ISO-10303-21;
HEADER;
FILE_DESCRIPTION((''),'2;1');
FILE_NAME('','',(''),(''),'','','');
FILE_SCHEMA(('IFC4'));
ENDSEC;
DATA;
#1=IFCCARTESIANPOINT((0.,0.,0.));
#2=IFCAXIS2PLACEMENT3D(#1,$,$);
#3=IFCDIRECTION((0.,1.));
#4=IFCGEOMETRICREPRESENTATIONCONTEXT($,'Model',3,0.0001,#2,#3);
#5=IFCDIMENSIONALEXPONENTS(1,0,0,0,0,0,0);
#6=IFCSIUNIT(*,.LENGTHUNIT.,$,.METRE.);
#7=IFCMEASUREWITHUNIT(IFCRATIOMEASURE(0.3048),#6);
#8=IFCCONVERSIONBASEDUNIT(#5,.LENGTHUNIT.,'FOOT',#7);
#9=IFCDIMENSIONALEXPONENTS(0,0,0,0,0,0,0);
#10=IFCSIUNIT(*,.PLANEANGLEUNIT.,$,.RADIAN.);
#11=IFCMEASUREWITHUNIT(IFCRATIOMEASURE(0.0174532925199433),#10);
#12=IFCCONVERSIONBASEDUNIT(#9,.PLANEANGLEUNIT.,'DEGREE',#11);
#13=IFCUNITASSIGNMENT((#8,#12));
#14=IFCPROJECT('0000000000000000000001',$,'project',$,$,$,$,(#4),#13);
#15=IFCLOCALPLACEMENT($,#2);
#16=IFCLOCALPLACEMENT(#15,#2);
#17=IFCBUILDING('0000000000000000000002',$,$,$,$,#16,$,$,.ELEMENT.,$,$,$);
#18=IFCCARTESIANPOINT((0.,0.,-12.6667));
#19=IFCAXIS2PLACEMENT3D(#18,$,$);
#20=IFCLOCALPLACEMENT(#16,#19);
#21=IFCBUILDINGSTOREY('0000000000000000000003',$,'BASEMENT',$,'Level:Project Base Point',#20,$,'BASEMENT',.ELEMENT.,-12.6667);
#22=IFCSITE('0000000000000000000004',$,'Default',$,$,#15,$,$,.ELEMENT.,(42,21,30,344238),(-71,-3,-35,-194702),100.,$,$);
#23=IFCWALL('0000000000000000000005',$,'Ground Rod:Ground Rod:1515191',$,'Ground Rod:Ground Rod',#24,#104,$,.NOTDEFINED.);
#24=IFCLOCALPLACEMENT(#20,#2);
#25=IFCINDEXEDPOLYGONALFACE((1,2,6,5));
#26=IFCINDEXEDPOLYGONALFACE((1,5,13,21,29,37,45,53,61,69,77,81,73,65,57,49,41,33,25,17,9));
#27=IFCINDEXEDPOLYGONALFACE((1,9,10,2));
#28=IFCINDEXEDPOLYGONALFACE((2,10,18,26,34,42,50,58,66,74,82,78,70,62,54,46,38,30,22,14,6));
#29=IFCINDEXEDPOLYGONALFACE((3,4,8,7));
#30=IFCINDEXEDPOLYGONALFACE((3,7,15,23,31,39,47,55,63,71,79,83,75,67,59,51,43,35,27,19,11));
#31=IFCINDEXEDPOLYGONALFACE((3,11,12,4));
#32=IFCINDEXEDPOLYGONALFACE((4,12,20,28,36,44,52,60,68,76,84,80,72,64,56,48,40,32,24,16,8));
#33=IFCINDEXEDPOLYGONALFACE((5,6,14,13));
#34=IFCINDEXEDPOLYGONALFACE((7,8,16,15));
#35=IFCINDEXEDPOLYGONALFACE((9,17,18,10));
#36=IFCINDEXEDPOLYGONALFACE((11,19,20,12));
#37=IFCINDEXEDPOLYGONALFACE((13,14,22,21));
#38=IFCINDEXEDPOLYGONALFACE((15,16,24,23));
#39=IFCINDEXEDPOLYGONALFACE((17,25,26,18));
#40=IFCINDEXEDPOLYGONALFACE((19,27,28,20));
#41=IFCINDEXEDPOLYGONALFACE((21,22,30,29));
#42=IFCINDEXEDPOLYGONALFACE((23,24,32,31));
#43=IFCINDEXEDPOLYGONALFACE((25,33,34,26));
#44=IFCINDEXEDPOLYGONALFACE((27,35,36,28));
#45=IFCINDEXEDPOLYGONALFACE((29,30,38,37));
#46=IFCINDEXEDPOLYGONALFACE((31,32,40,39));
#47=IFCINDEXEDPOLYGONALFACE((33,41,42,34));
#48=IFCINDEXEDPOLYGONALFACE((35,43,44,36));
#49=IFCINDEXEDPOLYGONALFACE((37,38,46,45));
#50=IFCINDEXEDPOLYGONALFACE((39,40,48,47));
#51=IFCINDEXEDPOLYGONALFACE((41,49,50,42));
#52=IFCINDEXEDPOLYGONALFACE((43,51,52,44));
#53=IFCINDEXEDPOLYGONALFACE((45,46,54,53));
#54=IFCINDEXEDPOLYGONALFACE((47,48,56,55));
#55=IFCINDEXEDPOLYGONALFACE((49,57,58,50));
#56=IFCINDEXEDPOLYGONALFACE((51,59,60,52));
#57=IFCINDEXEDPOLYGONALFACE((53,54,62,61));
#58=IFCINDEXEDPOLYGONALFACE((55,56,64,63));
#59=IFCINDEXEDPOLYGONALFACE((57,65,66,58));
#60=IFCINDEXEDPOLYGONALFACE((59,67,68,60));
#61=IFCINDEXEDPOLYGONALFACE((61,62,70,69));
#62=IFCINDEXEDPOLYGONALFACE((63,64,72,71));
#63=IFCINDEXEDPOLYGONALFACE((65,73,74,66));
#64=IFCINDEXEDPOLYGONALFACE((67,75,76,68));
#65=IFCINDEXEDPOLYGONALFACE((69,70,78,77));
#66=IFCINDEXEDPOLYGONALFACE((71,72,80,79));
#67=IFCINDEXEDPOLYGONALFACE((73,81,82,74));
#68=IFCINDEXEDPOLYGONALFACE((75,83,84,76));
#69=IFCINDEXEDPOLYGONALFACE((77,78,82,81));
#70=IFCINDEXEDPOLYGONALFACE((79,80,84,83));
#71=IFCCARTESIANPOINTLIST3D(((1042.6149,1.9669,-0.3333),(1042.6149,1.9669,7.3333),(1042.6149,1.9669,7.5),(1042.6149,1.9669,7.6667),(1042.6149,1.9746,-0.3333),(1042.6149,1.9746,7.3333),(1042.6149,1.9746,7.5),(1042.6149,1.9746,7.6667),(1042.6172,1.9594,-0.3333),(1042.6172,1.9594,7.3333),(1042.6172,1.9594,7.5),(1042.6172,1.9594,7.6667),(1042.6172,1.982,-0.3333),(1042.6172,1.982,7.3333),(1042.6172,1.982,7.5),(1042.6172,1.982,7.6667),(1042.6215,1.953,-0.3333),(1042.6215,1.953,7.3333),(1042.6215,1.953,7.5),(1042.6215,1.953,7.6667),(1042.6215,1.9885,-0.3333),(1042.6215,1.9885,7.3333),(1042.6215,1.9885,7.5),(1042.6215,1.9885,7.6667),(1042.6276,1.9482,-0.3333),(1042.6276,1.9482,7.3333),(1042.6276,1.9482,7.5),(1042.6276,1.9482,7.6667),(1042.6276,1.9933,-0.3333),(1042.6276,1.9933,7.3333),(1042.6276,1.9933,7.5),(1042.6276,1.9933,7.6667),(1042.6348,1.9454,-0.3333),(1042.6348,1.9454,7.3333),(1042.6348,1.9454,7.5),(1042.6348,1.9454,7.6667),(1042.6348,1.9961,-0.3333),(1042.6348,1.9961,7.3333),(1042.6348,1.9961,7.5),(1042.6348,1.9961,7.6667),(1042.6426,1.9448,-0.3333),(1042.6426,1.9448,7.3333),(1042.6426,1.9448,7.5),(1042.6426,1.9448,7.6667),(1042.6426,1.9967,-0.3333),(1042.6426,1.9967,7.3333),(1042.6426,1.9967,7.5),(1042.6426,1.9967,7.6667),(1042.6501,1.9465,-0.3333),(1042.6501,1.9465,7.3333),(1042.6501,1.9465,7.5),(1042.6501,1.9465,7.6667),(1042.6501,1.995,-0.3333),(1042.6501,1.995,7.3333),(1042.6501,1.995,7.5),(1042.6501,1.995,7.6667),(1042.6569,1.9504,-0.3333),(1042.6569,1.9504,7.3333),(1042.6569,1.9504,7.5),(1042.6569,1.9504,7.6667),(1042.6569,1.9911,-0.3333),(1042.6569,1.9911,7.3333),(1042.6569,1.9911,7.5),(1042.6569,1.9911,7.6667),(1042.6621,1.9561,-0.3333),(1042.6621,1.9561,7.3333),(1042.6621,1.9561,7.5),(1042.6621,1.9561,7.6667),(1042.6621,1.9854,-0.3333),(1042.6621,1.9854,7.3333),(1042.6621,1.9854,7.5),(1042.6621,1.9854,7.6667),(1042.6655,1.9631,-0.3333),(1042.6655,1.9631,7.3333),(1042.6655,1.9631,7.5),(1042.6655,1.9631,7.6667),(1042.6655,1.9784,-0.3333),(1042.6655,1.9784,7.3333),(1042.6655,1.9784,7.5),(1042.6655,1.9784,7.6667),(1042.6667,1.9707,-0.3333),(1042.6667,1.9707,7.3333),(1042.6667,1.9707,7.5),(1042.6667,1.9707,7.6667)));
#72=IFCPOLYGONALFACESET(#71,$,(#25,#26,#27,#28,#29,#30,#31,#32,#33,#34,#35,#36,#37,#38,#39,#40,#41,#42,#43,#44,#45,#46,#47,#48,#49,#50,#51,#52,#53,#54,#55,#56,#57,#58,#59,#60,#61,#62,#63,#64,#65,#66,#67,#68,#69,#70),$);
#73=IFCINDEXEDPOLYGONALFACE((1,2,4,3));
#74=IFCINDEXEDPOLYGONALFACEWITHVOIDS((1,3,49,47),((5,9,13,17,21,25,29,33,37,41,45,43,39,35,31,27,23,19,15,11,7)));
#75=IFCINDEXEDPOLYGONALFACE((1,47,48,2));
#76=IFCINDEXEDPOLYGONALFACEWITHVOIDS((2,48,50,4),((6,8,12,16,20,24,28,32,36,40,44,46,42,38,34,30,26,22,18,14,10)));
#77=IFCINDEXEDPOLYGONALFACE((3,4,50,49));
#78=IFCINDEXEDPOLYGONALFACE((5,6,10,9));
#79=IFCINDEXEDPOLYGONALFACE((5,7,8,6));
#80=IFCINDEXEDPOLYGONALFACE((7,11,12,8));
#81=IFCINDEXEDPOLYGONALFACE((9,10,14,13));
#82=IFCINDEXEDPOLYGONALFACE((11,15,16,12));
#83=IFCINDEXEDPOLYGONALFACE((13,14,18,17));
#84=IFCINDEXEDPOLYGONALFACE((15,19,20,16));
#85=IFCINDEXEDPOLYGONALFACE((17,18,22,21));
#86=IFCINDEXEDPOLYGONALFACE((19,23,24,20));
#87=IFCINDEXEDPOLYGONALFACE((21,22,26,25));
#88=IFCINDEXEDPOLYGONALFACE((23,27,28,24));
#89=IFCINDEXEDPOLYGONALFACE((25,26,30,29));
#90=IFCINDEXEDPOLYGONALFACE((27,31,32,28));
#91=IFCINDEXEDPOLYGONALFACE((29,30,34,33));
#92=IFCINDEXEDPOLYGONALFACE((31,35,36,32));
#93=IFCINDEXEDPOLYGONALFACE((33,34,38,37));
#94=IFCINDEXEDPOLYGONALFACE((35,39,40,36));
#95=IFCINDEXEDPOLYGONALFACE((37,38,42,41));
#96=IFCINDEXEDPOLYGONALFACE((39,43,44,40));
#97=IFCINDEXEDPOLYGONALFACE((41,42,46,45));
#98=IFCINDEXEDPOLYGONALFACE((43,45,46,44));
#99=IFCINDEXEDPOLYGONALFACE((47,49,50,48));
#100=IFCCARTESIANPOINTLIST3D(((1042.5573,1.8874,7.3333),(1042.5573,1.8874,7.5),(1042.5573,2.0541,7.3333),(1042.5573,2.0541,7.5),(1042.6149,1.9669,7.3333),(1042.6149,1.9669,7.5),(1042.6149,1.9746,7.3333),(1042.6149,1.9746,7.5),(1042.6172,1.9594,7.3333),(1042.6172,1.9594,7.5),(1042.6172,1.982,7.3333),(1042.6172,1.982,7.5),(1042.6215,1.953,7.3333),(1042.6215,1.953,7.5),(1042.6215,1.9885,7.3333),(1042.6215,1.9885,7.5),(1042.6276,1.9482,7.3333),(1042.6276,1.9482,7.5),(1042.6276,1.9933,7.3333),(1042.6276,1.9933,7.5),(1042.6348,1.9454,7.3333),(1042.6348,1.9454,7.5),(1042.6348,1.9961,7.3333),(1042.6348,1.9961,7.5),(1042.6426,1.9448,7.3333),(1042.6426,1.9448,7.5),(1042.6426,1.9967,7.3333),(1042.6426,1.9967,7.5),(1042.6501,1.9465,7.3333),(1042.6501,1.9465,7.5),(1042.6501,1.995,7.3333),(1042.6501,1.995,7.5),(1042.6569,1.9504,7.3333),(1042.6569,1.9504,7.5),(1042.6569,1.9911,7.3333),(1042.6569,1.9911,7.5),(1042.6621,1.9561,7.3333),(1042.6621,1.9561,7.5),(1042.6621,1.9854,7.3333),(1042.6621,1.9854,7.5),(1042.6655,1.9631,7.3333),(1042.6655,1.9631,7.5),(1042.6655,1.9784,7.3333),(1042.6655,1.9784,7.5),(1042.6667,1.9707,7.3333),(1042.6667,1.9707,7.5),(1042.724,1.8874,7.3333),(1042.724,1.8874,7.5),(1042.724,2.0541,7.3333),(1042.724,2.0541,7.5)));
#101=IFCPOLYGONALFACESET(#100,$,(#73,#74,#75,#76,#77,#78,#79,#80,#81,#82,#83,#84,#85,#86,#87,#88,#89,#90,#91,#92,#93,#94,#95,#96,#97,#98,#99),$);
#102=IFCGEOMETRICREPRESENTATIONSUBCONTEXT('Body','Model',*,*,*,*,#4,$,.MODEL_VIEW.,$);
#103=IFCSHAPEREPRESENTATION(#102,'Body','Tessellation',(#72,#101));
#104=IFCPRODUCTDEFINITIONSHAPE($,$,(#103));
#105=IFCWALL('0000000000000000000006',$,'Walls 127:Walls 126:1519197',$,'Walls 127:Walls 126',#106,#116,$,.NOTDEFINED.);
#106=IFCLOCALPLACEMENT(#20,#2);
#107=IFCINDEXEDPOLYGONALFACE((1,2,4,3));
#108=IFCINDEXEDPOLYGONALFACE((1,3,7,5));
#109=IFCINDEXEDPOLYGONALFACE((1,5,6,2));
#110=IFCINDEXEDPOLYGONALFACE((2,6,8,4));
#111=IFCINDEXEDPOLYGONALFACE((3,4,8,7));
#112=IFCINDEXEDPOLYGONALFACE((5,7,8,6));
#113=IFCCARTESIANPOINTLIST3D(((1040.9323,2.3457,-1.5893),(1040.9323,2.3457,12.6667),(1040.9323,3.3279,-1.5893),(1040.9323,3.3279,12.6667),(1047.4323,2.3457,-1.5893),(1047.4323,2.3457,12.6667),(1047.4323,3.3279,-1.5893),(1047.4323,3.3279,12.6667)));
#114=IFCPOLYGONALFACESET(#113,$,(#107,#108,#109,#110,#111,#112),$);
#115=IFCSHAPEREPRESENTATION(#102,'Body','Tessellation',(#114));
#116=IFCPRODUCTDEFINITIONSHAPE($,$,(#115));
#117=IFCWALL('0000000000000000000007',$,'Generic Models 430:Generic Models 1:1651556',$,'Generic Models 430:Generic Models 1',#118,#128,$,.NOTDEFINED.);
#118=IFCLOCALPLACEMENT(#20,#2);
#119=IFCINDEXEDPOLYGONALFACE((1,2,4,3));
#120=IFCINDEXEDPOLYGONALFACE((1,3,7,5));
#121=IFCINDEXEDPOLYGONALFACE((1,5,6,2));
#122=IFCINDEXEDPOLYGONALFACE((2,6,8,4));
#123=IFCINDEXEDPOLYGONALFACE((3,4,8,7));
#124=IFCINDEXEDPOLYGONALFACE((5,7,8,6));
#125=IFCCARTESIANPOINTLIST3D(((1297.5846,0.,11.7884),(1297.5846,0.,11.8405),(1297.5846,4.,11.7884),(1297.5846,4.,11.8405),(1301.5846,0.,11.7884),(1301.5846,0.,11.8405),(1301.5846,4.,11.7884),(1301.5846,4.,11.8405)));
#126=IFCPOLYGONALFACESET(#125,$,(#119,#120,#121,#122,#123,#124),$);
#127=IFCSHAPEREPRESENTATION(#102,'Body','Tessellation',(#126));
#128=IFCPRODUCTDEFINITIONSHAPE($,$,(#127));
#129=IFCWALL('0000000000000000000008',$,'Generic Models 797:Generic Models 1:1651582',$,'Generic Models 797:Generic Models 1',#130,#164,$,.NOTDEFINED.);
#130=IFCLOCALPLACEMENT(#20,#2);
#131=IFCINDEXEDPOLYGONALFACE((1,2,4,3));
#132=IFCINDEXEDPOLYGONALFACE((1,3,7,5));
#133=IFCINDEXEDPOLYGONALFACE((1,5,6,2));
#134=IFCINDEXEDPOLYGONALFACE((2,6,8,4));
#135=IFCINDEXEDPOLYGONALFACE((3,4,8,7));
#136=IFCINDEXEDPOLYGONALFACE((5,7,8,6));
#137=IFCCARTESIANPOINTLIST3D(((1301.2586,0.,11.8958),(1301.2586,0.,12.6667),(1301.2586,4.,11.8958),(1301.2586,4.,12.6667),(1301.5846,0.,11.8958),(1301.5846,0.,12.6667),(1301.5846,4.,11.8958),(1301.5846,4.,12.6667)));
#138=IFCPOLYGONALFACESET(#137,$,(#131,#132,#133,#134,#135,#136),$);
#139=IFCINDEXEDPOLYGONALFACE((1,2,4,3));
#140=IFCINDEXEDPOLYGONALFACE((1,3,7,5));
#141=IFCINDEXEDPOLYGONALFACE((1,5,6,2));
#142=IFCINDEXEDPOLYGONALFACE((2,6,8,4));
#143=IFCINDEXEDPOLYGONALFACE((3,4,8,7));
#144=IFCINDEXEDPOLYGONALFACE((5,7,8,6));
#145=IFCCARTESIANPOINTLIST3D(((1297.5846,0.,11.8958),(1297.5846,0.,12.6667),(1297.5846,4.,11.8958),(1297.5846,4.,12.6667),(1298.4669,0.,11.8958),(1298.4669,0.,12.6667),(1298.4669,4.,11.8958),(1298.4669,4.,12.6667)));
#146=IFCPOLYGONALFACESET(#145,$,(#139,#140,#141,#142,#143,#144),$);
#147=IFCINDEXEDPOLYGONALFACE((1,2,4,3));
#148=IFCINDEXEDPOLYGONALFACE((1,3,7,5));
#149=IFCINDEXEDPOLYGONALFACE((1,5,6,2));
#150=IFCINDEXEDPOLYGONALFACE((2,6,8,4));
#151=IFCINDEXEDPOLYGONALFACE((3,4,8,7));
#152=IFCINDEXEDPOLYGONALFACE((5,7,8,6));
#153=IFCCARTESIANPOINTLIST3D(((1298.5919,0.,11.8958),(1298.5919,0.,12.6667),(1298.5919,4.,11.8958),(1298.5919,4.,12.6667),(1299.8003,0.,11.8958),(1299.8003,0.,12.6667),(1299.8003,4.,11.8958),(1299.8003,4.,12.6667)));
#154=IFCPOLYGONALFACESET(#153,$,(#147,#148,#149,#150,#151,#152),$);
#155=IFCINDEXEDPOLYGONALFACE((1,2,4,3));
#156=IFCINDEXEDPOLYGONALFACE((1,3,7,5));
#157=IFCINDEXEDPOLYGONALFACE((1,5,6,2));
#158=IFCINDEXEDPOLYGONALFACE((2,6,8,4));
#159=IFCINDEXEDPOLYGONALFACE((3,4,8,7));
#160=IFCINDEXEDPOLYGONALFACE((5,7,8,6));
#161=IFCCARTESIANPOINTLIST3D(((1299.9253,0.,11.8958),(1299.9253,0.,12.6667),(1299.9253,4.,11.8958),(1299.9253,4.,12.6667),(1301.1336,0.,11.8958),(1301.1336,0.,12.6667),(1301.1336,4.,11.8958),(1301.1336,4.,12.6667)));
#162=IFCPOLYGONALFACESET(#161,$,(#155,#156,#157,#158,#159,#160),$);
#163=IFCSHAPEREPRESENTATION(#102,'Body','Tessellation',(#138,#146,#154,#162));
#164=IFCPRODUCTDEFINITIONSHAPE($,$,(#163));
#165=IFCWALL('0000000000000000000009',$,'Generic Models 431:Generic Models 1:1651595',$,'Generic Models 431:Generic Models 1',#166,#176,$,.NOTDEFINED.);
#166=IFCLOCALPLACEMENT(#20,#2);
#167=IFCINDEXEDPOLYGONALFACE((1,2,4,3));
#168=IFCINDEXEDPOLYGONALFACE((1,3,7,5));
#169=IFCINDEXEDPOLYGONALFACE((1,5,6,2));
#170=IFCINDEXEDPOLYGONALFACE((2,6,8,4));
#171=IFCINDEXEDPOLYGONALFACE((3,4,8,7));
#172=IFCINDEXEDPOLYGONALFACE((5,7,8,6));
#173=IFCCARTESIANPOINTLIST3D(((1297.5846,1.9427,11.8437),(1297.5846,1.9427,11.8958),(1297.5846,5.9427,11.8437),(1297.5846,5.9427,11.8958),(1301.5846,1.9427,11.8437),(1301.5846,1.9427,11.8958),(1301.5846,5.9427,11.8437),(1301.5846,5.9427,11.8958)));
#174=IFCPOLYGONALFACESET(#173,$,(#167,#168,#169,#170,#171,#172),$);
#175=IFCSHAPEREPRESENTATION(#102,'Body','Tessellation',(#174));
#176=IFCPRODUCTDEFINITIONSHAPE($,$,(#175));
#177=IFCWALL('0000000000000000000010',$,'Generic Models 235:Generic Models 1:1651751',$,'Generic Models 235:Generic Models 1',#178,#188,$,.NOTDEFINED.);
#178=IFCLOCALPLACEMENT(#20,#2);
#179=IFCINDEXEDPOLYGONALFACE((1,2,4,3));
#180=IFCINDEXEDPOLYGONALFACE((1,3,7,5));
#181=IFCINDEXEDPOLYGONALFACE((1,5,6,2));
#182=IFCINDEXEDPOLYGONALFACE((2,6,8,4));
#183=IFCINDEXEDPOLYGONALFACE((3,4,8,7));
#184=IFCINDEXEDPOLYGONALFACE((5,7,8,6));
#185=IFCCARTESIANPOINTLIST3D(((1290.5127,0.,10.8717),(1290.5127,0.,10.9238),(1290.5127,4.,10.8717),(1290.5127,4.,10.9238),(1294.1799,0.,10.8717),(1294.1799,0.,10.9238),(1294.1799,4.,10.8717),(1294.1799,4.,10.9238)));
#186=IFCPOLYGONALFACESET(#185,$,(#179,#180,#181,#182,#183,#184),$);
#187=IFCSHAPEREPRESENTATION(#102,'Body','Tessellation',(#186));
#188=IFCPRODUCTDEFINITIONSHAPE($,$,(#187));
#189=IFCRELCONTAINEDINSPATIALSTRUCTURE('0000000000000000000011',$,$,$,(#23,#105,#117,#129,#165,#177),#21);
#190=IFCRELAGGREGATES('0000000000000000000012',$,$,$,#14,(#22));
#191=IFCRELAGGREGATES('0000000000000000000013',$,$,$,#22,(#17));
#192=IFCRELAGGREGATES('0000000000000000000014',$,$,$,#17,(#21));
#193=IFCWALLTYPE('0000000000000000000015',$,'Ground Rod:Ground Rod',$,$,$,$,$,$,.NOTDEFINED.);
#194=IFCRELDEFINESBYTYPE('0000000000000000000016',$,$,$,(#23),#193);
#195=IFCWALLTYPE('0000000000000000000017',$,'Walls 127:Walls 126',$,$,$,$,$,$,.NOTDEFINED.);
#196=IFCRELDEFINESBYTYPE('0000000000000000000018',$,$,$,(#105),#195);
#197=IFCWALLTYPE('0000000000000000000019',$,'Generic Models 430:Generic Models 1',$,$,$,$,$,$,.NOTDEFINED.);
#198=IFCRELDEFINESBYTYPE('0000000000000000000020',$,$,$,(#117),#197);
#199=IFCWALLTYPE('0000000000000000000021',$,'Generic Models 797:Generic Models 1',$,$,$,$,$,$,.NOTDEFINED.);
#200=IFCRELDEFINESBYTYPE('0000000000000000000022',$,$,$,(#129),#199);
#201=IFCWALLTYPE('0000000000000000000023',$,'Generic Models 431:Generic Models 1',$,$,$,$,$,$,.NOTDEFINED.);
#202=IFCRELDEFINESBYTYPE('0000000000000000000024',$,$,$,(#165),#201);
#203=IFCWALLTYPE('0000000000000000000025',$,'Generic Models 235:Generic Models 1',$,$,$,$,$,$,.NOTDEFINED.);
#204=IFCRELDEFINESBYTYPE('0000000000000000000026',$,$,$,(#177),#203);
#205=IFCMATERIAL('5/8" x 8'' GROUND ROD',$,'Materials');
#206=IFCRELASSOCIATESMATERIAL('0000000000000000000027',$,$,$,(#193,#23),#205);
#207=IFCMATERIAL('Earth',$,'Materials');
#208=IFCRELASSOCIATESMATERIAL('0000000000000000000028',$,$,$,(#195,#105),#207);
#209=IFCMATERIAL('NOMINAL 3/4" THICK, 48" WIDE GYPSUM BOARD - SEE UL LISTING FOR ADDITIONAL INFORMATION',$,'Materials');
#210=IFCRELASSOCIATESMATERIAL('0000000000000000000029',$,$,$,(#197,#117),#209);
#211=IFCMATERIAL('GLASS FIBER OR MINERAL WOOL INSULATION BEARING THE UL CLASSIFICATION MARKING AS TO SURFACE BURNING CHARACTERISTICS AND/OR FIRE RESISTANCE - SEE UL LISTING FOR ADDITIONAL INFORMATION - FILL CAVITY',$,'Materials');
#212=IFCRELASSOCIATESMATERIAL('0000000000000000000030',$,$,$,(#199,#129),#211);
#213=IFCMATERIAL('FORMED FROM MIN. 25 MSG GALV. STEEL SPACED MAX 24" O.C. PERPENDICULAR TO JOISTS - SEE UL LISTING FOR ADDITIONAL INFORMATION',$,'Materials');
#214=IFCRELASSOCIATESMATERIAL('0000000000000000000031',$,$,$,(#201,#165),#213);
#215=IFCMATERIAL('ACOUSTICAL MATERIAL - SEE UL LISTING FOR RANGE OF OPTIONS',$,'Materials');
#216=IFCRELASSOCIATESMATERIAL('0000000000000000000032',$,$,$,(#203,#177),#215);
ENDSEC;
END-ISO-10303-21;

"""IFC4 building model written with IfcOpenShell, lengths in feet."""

from ifc_helpers import new_model, entity, si_unit, converted_unit, direction, frame, frame_2d, origin, origin_2d_with_axis, place, context, subcontext, project, spatial, rectangle, circle, extrude, material, type_object, element, save


model = new_model("IFC4")

# Units and contexts
model_context = context("Model", 3, precision=0.0001, world=origin(), true_north=direction((0.0, 1.0)))
body_context = subcontext(model_context, "Body", "Model", "MODEL_VIEW")
ifc_project = project(units=[converted_unit("LENGTHUNIT", "FOOT", entity("IfcRatioMeasure", 0.3048), si_unit("LENGTHUNIT", "METRE"), dimensions=[1, 0, 0, 0, 0, 0, 0]), converted_unit("PLANEANGLEUNIT", "DEGREE", entity("IfcRatioMeasure", 0.0174532925199433), si_unit("PLANEANGLEUNIT", "RADIAN"), dimensions=[0, 0, 0, 0, 0, 0, 0])], contexts=[model_context])

# Site, building, storey
site_placement = place(None, origin())
site = spatial("IfcSite", under=ifc_project, at=site_placement, Name="Default", CompositionType="ELEMENT", RefLatitude=(42, 21, 30, 344238), RefLongitude=(-71, -3, -35, -194702), RefElevation=100.0)
building_placement = place(site_placement, origin())
building = spatial("IfcBuilding", under=site, at=building_placement, CompositionType="ELEMENT")
storey_placement = place(building_placement, frame((0.0, 0.0, -12.6667)))
storey = spatial("IfcBuildingStorey", under=building, at=storey_placement, Name="BASEMENT", ObjectType="Level:Project Base Point", LongName="BASEMENT", CompositionType="ELEMENT", Elevation=-12.6667)

# Wall, opening
ifc_material_1 = material(Name="5/8\" x 8' GROUND ROD", Category="Materials")
wall_type_1 = type_object("IfcWallType", Name="Ground Rod:Ground Rod", PredefinedType="NOTDEFINED", material=ifc_material_1)
wall_1_placement = place(storey_placement, frame((1042.5573, 1.8874, -0.3333)))
wall_1 = element("IfcWall", 1, at=wall_1_placement, inside=storey, type_object=wall_type_1, material=ifc_material_1, Name="Ground Rod:Ground Rod:1515191", ObjectType="Ground Rod:Ground Rod", PredefinedType="NOTDEFINED", context=body_context, shape_type="SweptSolid", body=[
    extrude(circle(Radius=0.026, at=origin_2d_with_axis()), frame((0.0833, 0.0833, 0.0)), (0.0, 0.0, 1.0), 8.0),
    extrude(rectangle(XDim=0.1667, YDim=0.1667, at=frame_2d((0.0, 0.0), x_axis=(1.0, 0.0))), frame((0.0833, 0.0833, 7.6667), z_axis=(0.0, 0.0, 1.0), x_axis=(-1.0, 0.0, 0.0)), (0.0, 0.0, 1.0), 0.1667),
])
opening_placement = place(storey_placement, frame((1042.5573, 1.8874, -0.3333)))
element("IfcOpeningElement", 2, at=opening_placement, cuts=wall_1, PredefinedType="OPENING", context=body_context, shape_type="SweptSolid", body=[
    extrude(circle(Radius=0.026, at=frame_2d((0.0, 0.0), x_axis=(1.0, 0.0))), frame((0.0833, 0.0833, 7.6667)), (0.0, 0.0, 1.0), 0.1667),
])

# Walls
ifc_material_2 = material(Name="Earth", Category="Materials")
wall_type_2 = type_object("IfcWallType", Name="Walls 127:Walls 126", PredefinedType="NOTDEFINED", material=ifc_material_2)
wall_2_placement = place(storey_placement, frame((1040.9323, 2.3457, -1.5893)))
element("IfcWall", 3, at=wall_2_placement, inside=storey, type_object=wall_type_2, material=ifc_material_2, Name="Walls 127:Walls 126:1519197", ObjectType="Walls 127:Walls 126", PredefinedType="NOTDEFINED", context=body_context, shape_type="SweptSolid", body=[
    extrude(rectangle(XDim=0.9821, YDim=6.5, at=frame_2d((0.0, 0.0), x_axis=(1.0, 0.0))), frame((3.25, 0.4911, 0.0), z_axis=(0.0, 0.0, 1.0), x_axis=(0.0, 1.0, 0.0)), (0.0, 0.0, 1.0), 14.256),
])
ifc_material_3 = material(Name="NOMINAL 3/4\" THICK, 48\" WIDE GYPSUM BOARD - SEE UL LISTING FOR ADDITIONAL INFORMATION", Category="Materials")
wall_type_3 = type_object("IfcWallType", Name="Generic Models 430:Generic Models 1", PredefinedType="NOTDEFINED", material=ifc_material_3)
wall_3_placement = place(storey_placement, frame((1297.5846, 0.0, 11.7884), z_axis=(0.0, 0.0, 1.0), x_axis=(0.0, 1.0, 0.0)))
element("IfcWall", 4, at=wall_3_placement, inside=storey, type_object=wall_type_3, material=ifc_material_3, Name="Generic Models 430:Generic Models 1:1651556", ObjectType="Generic Models 430:Generic Models 1", PredefinedType="NOTDEFINED", context=body_context, shape_type="SweptSolid", body=[
    extrude(rectangle(XDim=4.0, YDim=4.0, at=origin_2d_with_axis()), frame((2.0, -2.0, 0.0)), (0.0, 0.0, 1.0), 0.0521),
])
ifc_material_4 = material(Name="GLASS FIBER OR MINERAL WOOL INSULATION BEARING THE UL CLASSIFICATION MARKING AS TO SURFACE BURNING CHARACTERISTICS AND/OR FIRE RESISTANCE - SEE UL LISTING FOR ADDITIONAL INFORMATION - FILL CAVITY", Category="Materials")
wall_type_4 = type_object("IfcWallType", Name="Generic Models 797:Generic Models 1", PredefinedType="NOTDEFINED", material=ifc_material_4)
wall_4_placement = place(storey_placement, frame((1297.5846, 0.0, 11.8958), z_axis=(0.0, 0.0, 1.0), x_axis=(0.0, 1.0, 0.0)))
element("IfcWall", 5, at=wall_4_placement, inside=storey, type_object=wall_type_4, material=ifc_material_4, Name="Generic Models 797:Generic Models 1:1651582", ObjectType="Generic Models 797:Generic Models 1", PredefinedType="NOTDEFINED", context=body_context, shape_type="SweptSolid", body=[
    extrude(rectangle(XDim=4.0, YDim=0.326, at=origin_2d_with_axis()), frame((2.0, -3.837, 0.0)), (0.0, 0.0, 1.0), 0.7708),
    extrude(rectangle(XDim=4.0, YDim=0.8824, at=origin_2d_with_axis()), frame((2.0, -0.4412, 0.0)), (0.0, 0.0, 1.0), 0.7708),
    extrude(rectangle(XDim=4.0, YDim=1.2083, at=frame_2d((0.0, 0.0), x_axis=(1.0, 0.0))), frame((2.0, -1.6115, 0.0)), (0.0, 0.0, 1.0), 0.7708),
    extrude(rectangle(XDim=4.0, YDim=1.2083, at=frame_2d((0.0, 0.0), x_axis=(1.0, 0.0))), frame((2.0, -2.9449, 0.0)), (0.0, 0.0, 1.0), 0.7708),
])
ifc_material_5 = material(Name="FORMED FROM MIN. 25 MSG GALV. STEEL SPACED MAX 24\" O.C. PERPENDICULAR TO JOISTS - SEE UL LISTING FOR ADDITIONAL INFORMATION", Category="Materials")
wall_type_5 = type_object("IfcWallType", Name="Generic Models 431:Generic Models 1", PredefinedType="NOTDEFINED", material=ifc_material_5)
wall_5_placement = place(storey_placement, frame((1297.5846, 1.9427, 11.8437), z_axis=(0.0, 0.0, 1.0), x_axis=(0.0, 1.0, 0.0)))
element("IfcWall", 6, at=wall_5_placement, inside=storey, type_object=wall_type_5, material=ifc_material_5, Name="Generic Models 431:Generic Models 1:1651595", ObjectType="Generic Models 431:Generic Models 1", PredefinedType="NOTDEFINED", context=body_context, shape_type="SweptSolid", body=[
    extrude(rectangle(XDim=4.0, YDim=4.0, at=frame_2d((0.0, 0.0), x_axis=(1.0, 0.0))), frame((2.0, -2.0, 0.0)), (0.0, 0.0, 1.0), 0.0521),
])
ifc_material_6 = material(Name="ACOUSTICAL MATERIAL - SEE UL LISTING FOR RANGE OF OPTIONS", Category="Materials")
wall_type_6 = type_object("IfcWallType", Name="Generic Models 235:Generic Models 1", PredefinedType="NOTDEFINED", material=ifc_material_6)
wall_6_placement = place(storey_placement, frame((1290.5127, 0.0, 10.8717), z_axis=(0.0, 0.0, 1.0), x_axis=(0.0, 1.0, 0.0)))
element("IfcWall", 7, at=wall_6_placement, inside=storey, type_object=wall_type_6, material=ifc_material_6, Name="Generic Models 235:Generic Models 1:1651751", ObjectType="Generic Models 235:Generic Models 1", PredefinedType="NOTDEFINED", context=body_context, shape_type="SweptSolid", body=[
    extrude(rectangle(XDim=4.0, YDim=3.6671, at=frame_2d((0.0, 0.0), x_axis=(1.0, 0.0))), frame((2.0, -1.8336, 0.0)), (0.0, 0.0, 1.0), 0.0521),
])

save(model, "model.ifc")
